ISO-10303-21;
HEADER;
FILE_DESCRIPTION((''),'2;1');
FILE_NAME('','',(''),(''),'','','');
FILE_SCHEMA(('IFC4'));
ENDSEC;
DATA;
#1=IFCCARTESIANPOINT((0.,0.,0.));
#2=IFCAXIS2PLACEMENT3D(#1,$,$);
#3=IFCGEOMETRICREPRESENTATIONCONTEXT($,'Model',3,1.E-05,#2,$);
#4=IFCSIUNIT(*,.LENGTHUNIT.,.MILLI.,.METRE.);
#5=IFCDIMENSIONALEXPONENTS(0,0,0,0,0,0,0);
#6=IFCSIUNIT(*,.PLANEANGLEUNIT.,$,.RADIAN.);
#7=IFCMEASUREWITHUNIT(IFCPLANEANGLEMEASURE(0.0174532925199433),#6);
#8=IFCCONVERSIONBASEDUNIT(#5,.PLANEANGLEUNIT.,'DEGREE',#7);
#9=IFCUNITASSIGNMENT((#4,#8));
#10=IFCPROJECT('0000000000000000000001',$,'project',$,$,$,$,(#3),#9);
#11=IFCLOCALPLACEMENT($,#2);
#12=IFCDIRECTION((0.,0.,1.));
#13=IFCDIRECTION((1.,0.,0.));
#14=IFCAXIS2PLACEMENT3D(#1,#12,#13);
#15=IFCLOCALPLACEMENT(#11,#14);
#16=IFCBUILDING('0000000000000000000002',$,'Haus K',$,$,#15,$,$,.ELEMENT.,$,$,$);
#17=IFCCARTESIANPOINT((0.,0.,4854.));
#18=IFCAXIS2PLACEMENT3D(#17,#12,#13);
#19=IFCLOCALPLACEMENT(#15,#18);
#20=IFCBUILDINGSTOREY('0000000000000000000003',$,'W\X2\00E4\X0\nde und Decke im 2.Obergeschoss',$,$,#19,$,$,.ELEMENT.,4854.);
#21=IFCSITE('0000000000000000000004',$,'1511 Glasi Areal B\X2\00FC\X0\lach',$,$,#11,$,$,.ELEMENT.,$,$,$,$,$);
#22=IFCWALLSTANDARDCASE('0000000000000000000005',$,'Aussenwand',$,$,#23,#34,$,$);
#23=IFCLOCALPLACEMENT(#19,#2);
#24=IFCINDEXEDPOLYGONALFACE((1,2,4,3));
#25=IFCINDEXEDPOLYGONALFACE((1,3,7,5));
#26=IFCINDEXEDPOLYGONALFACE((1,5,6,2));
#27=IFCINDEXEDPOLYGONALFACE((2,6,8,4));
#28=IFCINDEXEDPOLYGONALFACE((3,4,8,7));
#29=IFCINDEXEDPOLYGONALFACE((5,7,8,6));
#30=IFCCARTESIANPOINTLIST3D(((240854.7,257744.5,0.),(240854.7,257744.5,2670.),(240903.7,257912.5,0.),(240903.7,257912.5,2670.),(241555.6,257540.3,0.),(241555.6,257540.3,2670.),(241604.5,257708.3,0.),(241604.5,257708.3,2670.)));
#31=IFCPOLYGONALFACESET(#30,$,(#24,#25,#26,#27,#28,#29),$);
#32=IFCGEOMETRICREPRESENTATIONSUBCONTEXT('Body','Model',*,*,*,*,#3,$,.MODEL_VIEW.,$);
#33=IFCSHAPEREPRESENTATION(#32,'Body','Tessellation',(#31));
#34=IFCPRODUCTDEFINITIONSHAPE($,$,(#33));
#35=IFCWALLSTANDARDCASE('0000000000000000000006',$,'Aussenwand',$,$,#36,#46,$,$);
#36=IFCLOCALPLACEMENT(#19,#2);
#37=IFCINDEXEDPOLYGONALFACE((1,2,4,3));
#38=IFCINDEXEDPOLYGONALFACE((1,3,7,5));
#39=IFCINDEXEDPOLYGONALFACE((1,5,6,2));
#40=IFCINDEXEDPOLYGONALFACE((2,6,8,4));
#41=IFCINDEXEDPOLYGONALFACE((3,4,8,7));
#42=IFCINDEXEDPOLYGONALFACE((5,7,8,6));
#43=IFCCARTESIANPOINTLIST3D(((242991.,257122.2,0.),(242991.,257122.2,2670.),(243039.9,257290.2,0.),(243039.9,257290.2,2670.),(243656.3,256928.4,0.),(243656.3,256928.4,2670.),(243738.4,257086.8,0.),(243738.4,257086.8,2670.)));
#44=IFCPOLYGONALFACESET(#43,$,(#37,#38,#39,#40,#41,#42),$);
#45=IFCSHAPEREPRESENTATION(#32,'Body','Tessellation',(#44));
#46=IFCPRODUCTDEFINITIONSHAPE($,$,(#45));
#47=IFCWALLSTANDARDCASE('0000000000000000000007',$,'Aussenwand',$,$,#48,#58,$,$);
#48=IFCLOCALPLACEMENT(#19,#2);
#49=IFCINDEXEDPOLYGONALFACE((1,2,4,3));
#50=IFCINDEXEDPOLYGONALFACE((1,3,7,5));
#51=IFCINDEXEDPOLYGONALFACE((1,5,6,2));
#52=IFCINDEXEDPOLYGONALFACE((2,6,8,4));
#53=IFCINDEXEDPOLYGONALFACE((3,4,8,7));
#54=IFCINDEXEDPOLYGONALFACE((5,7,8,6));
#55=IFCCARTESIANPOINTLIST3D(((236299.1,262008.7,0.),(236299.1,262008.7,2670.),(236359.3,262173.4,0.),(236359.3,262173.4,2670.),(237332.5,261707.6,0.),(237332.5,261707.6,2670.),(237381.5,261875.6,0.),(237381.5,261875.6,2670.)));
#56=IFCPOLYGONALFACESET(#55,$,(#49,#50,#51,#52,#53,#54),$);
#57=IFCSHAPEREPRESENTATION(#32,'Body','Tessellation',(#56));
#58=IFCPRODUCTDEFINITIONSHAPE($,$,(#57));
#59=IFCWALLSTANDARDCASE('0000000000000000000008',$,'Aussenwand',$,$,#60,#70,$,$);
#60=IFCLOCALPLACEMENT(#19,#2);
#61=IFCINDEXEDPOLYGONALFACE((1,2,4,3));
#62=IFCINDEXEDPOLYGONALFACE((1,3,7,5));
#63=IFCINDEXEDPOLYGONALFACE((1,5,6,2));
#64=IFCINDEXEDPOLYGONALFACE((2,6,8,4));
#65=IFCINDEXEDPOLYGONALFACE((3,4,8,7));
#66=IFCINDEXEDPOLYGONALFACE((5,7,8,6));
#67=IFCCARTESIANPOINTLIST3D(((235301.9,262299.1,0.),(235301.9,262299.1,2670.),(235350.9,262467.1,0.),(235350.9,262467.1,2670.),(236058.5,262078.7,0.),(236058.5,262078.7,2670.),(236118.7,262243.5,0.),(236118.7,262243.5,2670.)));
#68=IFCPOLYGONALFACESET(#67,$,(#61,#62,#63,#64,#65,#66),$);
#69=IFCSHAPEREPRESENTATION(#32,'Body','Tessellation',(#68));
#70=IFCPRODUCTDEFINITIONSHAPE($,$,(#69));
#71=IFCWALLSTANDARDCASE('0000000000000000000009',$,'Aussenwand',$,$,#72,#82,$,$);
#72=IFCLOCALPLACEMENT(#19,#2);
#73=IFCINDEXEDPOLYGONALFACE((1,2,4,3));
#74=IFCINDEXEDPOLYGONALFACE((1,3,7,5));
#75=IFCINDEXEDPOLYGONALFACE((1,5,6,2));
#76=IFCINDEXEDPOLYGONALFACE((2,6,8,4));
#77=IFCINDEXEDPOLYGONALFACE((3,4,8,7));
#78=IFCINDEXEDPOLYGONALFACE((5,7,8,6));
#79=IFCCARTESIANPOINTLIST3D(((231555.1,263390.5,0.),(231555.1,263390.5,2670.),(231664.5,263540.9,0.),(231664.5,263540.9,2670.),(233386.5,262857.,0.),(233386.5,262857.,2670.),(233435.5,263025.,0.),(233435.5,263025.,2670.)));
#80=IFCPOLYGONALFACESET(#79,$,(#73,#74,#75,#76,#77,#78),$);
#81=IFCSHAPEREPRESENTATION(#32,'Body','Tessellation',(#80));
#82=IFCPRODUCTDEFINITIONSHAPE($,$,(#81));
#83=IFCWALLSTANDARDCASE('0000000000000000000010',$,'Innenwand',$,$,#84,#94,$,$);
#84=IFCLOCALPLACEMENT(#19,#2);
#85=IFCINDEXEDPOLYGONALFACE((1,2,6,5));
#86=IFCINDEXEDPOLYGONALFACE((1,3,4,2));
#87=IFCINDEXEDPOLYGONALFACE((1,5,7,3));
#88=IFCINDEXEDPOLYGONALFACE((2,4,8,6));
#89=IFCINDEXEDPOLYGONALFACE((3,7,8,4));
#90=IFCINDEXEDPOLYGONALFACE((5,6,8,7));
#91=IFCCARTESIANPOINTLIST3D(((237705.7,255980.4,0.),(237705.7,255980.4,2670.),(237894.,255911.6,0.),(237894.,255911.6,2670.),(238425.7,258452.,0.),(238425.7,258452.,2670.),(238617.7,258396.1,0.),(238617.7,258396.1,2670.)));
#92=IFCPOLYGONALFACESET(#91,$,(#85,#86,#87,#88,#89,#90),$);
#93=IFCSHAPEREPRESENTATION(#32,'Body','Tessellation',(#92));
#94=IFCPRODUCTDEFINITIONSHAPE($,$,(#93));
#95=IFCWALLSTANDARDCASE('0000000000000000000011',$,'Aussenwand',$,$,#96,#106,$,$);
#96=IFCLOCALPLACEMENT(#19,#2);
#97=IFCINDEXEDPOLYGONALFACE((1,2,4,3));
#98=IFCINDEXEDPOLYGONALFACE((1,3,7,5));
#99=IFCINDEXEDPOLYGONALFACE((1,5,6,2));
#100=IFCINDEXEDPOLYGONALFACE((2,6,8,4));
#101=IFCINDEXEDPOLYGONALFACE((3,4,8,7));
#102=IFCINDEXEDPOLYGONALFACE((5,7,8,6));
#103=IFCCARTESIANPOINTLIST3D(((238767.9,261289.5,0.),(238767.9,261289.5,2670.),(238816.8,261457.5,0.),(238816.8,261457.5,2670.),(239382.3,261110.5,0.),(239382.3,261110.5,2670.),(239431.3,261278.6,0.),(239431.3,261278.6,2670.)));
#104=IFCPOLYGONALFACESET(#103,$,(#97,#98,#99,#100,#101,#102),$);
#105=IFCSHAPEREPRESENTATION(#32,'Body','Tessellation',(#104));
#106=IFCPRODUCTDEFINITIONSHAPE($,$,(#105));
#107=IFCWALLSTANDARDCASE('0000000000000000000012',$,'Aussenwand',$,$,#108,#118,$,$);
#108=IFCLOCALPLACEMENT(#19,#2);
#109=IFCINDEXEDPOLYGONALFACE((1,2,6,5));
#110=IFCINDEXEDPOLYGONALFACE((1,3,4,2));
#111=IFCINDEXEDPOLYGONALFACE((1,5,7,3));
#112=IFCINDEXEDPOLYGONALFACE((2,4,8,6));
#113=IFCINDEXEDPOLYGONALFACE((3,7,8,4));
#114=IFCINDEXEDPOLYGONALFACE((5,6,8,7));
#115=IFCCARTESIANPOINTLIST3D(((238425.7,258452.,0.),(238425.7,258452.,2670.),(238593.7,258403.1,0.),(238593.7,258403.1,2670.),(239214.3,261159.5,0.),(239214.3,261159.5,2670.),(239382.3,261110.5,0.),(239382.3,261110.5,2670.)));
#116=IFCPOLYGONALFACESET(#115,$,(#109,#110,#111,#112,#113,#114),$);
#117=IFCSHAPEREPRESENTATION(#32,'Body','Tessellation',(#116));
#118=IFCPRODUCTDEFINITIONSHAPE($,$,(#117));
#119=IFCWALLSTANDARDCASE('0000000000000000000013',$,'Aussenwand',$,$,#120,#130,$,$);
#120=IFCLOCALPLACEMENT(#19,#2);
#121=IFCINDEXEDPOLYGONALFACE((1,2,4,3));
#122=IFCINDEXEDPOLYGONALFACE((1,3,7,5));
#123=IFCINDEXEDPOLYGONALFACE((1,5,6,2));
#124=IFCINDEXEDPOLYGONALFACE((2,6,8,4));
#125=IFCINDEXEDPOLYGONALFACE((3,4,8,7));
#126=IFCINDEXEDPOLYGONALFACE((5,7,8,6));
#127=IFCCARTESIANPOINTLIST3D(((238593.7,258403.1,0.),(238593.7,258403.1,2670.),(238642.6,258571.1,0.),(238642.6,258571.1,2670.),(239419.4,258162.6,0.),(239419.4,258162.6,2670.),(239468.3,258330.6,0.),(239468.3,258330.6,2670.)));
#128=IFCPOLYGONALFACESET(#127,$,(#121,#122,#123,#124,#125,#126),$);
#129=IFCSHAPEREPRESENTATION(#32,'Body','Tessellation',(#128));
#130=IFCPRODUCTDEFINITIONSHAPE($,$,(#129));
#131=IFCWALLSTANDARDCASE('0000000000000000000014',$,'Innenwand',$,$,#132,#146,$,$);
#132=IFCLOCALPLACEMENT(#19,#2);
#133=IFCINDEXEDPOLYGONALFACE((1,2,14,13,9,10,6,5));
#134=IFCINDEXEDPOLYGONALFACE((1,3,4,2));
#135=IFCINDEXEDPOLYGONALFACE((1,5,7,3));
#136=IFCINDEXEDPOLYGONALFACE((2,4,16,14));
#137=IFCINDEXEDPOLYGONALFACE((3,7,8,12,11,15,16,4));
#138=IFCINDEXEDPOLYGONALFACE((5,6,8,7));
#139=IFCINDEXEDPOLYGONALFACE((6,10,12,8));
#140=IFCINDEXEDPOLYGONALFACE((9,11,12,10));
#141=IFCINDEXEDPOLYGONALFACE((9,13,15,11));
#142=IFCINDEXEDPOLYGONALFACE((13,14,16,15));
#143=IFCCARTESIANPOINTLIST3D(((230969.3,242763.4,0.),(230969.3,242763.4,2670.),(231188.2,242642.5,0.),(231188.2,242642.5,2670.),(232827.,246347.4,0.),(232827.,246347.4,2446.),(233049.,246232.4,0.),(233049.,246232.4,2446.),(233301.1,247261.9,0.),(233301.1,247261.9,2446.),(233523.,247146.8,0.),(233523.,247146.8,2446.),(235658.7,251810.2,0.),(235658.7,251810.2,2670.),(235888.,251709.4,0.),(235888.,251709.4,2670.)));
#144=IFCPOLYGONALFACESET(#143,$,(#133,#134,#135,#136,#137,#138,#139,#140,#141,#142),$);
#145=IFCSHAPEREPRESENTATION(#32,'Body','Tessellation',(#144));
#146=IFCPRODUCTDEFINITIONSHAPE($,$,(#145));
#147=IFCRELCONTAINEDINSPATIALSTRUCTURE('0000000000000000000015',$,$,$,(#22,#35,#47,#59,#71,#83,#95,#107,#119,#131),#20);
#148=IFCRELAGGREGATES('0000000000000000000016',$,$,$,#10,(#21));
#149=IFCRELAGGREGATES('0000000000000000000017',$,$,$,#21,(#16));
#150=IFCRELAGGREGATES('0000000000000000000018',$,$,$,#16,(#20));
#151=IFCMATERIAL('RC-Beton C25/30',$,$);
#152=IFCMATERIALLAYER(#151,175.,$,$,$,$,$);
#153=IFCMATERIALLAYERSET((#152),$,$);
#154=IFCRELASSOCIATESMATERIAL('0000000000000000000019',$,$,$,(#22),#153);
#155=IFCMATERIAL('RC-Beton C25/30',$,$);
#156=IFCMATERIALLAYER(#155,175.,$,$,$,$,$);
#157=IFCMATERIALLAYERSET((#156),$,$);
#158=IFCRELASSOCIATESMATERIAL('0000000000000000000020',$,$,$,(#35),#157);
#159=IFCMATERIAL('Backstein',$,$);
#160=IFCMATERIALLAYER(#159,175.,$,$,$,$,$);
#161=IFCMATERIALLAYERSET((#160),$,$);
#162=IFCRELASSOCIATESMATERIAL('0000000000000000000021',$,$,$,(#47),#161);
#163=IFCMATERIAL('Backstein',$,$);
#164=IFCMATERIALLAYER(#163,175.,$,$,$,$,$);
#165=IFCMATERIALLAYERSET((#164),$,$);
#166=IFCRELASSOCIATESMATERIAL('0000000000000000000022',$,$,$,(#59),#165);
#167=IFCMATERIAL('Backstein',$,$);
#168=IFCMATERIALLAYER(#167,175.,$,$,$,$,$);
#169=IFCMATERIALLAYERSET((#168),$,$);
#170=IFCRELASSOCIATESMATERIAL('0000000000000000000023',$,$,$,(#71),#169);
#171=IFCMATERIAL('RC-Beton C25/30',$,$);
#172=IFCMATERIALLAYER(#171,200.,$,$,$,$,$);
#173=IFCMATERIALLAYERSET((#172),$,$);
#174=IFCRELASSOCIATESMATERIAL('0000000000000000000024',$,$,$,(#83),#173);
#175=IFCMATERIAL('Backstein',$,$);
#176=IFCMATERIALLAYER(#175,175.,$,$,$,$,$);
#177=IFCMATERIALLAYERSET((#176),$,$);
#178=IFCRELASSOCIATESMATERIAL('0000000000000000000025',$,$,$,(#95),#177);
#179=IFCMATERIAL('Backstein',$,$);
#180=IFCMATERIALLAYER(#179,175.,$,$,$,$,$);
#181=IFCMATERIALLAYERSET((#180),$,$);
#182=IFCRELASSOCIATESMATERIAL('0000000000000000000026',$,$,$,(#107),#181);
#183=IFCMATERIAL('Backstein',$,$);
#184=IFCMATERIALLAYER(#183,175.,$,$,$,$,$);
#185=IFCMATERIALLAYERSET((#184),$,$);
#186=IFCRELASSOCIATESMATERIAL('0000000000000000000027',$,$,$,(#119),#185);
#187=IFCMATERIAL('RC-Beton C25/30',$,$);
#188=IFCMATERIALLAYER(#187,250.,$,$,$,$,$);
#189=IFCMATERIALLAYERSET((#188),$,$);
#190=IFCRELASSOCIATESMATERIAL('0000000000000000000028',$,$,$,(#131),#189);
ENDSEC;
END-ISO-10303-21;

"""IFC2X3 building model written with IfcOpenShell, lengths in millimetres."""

from ifc_helpers import new_model, entity, si_unit, converted_unit, frame, frame_2d, origin, origin_with_axes, place, context, subcontext, project, spatial, polyline, rectangle, outline, extrude, material, layer, layer_set, layer_usage, element, save


model = new_model("IFC2X3")

# Units and contexts
model_context = context("Model", 3, precision=1e-05, world=origin())
body_context = subcontext(model_context, "Body", "Model", "MODEL_VIEW")
ifc_project = project(units=[si_unit("LENGTHUNIT", "METRE", prefix="MILLI"), converted_unit("PLANEANGLEUNIT", "DEGREE", entity("IfcPlaneAngleMeasure", 0.0174532925199433), si_unit("PLANEANGLEUNIT", "RADIAN"), dimensions=[0, 0, 0, 0, 0, 0, 0])], contexts=[model_context])

# Site, building, storey
site_placement = place(None, origin())
site = spatial("IfcSite", under=ifc_project, at=site_placement, Name="1511 Glasi Areal Bülach", CompositionType="ELEMENT")
building_placement = place(site_placement, origin_with_axes())
building = spatial("IfcBuilding", under=site, at=building_placement, Name="Haus K", CompositionType="ELEMENT")
storey_placement = place(building_placement, frame((0.0, 0.0, 4854.0), z_axis=(0.0, 0.0, 1.0), x_axis=(1.0, 0.0, 0.0)))
storey = spatial("IfcBuildingStorey", under=building, at=storey_placement, Name="Wände und Decke im 2.Obergeschoss", CompositionType="ELEMENT", Elevation=4854.0)

# Walls
ifc_material_1 = material(Name="RC-Beton C25/30")
ifc_layer_1 = layer(ifc_material_1, 175.0)
ifc_layer_set_1 = layer_set([ifc_layer_1])
ifc_layer_usage_1 = layer_usage(ifc_layer_set_1, "AXIS2", "POSITIVE", 0.0)
wall_1_placement = place(storey_placement, frame((241604.5, 257708.3, 0.0), z_axis=(0.0, 0.0, 1.0), x_axis=(-0.960099, 0.279661, 0.0)))
element("IfcWallStandardCase", 1, at=wall_1_placement, inside=storey, material=ifc_layer_usage_1, Name="Aussenwand", context=body_context, shape_type="SweptSolid", body=[
    extrude(rectangle(XDim=730.0, YDim=175.0, at=frame_2d((365.0, 87.5), x_axis=(1.0, 0.0))), origin_with_axes(), (0.0, 0.0, 1.0), 2670.0),
])
ifc_material_2 = material(Name="RC-Beton C25/30")
ifc_layer_2 = layer(ifc_material_2, 175.0)
ifc_layer_set_2 = layer_set([ifc_layer_2])
ifc_layer_usage_2 = layer_usage(ifc_layer_set_2, "AXIS2", "POSITIVE", 0.0)
wall_2_placement = place(storey_placement, frame((243738.4, 257086.8, 0.0), z_axis=(0.0, 0.0, 1.0), x_axis=(-0.960099, 0.279661, 0.0)))
element("IfcWallStandardCase", 2, at=wall_2_placement, inside=storey, material=ifc_layer_usage_2, Name="Aussenwand", context=body_context, shape_type="SweptSolid", body=[
    extrude(outline(polyline([(0.0, 0.0), (727.5, 0.0), (727.5, 175.0), (34.5, 175.0), (0.0, 0.0)])), origin_with_axes(), (0.0, 0.0, 1.0), 2670.0),
])
ifc_material_3 = material(Name="Backstein")
ifc_layer_3 = layer(ifc_material_3, 175.0)
ifc_layer_set_3 = layer_set([ifc_layer_3])
ifc_layer_usage_3 = layer_usage(ifc_layer_set_3, "AXIS2", "POSITIVE", 0.0)
wall_3_placement = place(storey_placement, frame((237381.5, 261875.6, 0.0), z_axis=(0.0, 0.0, 1.0), x_axis=(-0.960099, 0.279661, 0.0)))
element("IfcWallStandardCase", 3, at=wall_3_placement, inside=storey, material=ifc_layer_usage_3, Name="Aussenwand", context=body_context, shape_type="SweptSolid", body=[
    extrude(outline(polyline([(0.0, 0.0), (1064.7, 0.0), (1076.4, 175.0), (0.0, 175.0), (0.0, 0.0)])), origin_with_axes(), (0.0, 0.0, 1.0), 2670.0),
])
ifc_material_4 = material(Name="Backstein")
ifc_layer_4 = layer(ifc_material_4, 175.0)
ifc_layer_set_4 = layer_set([ifc_layer_4])
ifc_layer_usage_4 = layer_usage(ifc_layer_set_4, "AXIS2", "POSITIVE", 0.0)
wall_4_placement = place(storey_placement, frame((236118.7, 262243.5, 0.0), z_axis=(0.0, 0.0, 1.0), x_axis=(-0.960099, 0.279661, 0.0)))
element("IfcWallStandardCase", 4, at=wall_4_placement, inside=storey, material=ifc_layer_usage_4, Name="Aussenwand", context=body_context, shape_type="SweptSolid", body=[
    extrude(outline(polyline([(0.0, 0.0), (799.8, 0.0), (799.8, 175.0), (11.7, 175.0), (0.0, 0.0)])), origin_with_axes(), (0.0, 0.0, 1.0), 2670.0),
])
ifc_material_5 = material(Name="Backstein")
ifc_layer_5 = layer(ifc_material_5, 175.0)
ifc_layer_set_5 = layer_set([ifc_layer_5])
ifc_layer_usage_5 = layer_usage(ifc_layer_set_5, "AXIS2", "POSITIVE", 0.0)
wall_5_placement = place(storey_placement, frame((233435.5, 263025.0, 0.0), z_axis=(0.0, 0.0, 1.0), x_axis=(-0.960099, 0.279661, 0.0)))
element("IfcWallStandardCase", 5, at=wall_5_placement, inside=storey, material=ifc_layer_usage_5, Name="Aussenwand", context=body_context, shape_type="SweptSolid", body=[
    extrude(outline(polyline([(0.0, 0.0), (1844.5, 0.0), (1907.6, 175.0), (0.0, 175.0), (0.0, 0.0)])), origin_with_axes(), (0.0, 0.0, 1.0), 2670.0),
])
ifc_material_6 = material(Name="RC-Beton C25/30")
ifc_layer_6 = layer(ifc_material_6, 200.0)
ifc_layer_set_6 = layer_set([ifc_layer_6])
ifc_layer_usage_6 = layer_usage(ifc_layer_set_6, "AXIS2", "POSITIVE", 0.0)
wall_6_placement = place(storey_placement, frame((238425.7, 258452.0, 0.0), z_axis=(0.0, 0.0, 1.0), x_axis=(-0.279661, -0.960099, 0.0)))
element("IfcWallStandardCase", 6, at=wall_6_placement, inside=storey, material=ifc_layer_usage_6, Name="Innenwand", context=body_context, shape_type="SweptSolid", body=[
    extrude(outline(polyline([(0.0, 0.0), (2574.3, 0.0), (2587.7, 200.0), (0.0, 200.0), (0.0, 0.0)])), origin_with_axes(), (0.0, 0.0, 1.0), 2670.0),
])
ifc_material_7 = material(Name="Backstein")
ifc_layer_7 = layer(ifc_material_7, 175.0)
ifc_layer_set_7 = layer_set([ifc_layer_7])
ifc_layer_usage_7 = layer_usage(ifc_layer_set_7, "AXIS2", "POSITIVE", 0.0)
wall_7_placement = place(storey_placement, frame((239431.3, 261278.6, 0.0), z_axis=(0.0, 0.0, 1.0), x_axis=(-0.960099, 0.279661, 0.0)))
element("IfcWallStandardCase", 7, at=wall_7_placement, inside=storey, material=ifc_layer_usage_7, Name="Aussenwand", context=body_context, shape_type="SweptSolid", body=[
    extrude(rectangle(XDim=640.0, YDim=175.0, at=frame_2d((320.0, 87.5), x_axis=(1.0, 0.0))), origin_with_axes(), (0.0, 0.0, 1.0), 2670.0),
])
ifc_material_8 = material(Name="Backstein")
ifc_layer_8 = layer(ifc_material_8, 175.0)
ifc_layer_set_8 = layer_set([ifc_layer_8])
ifc_layer_usage_8 = layer_usage(ifc_layer_set_8, "AXIS2", "POSITIVE", 0.0)
wall_8_placement = place(storey_placement, frame((238593.7, 258403.1, 0.0), z_axis=(0.0, 0.0, 1.0), x_axis=(0.279661, 0.960099, 0.0)))
element("IfcWallStandardCase", 8, at=wall_8_placement, inside=storey, material=ifc_layer_usage_8, Name="Aussenwand", context=body_context, shape_type="SweptSolid", body=[
    extrude(rectangle(XDim=2820.0, YDim=175.0, at=frame_2d((1410.0, 87.5), x_axis=(1.0, 0.0))), origin_with_axes(), (0.0, 0.0, 1.0), 2670.0),
])
ifc_material_9 = material(Name="Backstein")
ifc_layer_9 = layer(ifc_material_9, 175.0)
ifc_layer_set_9 = layer_set([ifc_layer_9])
ifc_layer_usage_9 = layer_usage(ifc_layer_set_9, "AXIS2", "POSITIVE", 0.0)
wall_9_placement = place(storey_placement, frame((239468.3, 258330.6, 0.0), z_axis=(0.0, 0.0, 1.0), x_axis=(-0.960099, 0.279661, 0.0)))
element("IfcWallStandardCase", 9, at=wall_9_placement, inside=storey, material=ifc_layer_usage_9, Name="Aussenwand", context=body_context, shape_type="SweptSolid", body=[
    extrude(rectangle(XDim=860.0, YDim=175.0, at=frame_2d((430.0, 87.5), x_axis=(1.0, 0.0))), origin_with_axes(), (0.0, 0.0, 1.0), 2670.0),
])

# Wall, opening
ifc_material_10 = material(Name="RC-Beton C25/30")
ifc_layer_10 = layer(ifc_material_10, 250.0)
ifc_layer_set_10 = layer_set([ifc_layer_10])
ifc_layer_usage_10 = layer_usage(ifc_layer_set_10, "AXIS2", "POSITIVE", 0.0)
wall_10_placement = place(storey_placement, frame((235658.7, 251810.2, 0.0), z_axis=(0.0, 0.0, 1.0), x_axis=(-0.4602, -0.887815, 0.0)))
wall_10 = element("IfcWallStandardCase", 10, at=wall_10_placement, inside=storey, material=ifc_layer_usage_10, Name="Innenwand", context=body_context, shape_type="SweptSolid", body=[
    extrude(outline(polyline([(0.0, 0.0), (10190.0, 0.0), (10196.6, 250.0), (-16.0, 250.0), (0.0, 0.0)])), origin_with_axes(), (0.0, 0.0, 1.0), 2670.0),
])
opening_placement = place(wall_10_placement, frame((5123.1, 0.0, 0.0), z_axis=(0.0, 1.0, 0.0), x_axis=(0.0, 0.0, 1.0)))
element("IfcOpeningElement", 11, at=opening_placement, cuts=wall_10, ObjectType="Opening", context=body_context, shape_type="SweptSolid", body=[
    extrude(rectangle(XDim=2446.0, YDim=1030.0, at=frame_2d((1223.0, 515.0), x_axis=(1.0, 0.0))), origin_with_axes(), (0.0, 0.0, 1.0), 250.0),
])

save(model, "model.ifc")
